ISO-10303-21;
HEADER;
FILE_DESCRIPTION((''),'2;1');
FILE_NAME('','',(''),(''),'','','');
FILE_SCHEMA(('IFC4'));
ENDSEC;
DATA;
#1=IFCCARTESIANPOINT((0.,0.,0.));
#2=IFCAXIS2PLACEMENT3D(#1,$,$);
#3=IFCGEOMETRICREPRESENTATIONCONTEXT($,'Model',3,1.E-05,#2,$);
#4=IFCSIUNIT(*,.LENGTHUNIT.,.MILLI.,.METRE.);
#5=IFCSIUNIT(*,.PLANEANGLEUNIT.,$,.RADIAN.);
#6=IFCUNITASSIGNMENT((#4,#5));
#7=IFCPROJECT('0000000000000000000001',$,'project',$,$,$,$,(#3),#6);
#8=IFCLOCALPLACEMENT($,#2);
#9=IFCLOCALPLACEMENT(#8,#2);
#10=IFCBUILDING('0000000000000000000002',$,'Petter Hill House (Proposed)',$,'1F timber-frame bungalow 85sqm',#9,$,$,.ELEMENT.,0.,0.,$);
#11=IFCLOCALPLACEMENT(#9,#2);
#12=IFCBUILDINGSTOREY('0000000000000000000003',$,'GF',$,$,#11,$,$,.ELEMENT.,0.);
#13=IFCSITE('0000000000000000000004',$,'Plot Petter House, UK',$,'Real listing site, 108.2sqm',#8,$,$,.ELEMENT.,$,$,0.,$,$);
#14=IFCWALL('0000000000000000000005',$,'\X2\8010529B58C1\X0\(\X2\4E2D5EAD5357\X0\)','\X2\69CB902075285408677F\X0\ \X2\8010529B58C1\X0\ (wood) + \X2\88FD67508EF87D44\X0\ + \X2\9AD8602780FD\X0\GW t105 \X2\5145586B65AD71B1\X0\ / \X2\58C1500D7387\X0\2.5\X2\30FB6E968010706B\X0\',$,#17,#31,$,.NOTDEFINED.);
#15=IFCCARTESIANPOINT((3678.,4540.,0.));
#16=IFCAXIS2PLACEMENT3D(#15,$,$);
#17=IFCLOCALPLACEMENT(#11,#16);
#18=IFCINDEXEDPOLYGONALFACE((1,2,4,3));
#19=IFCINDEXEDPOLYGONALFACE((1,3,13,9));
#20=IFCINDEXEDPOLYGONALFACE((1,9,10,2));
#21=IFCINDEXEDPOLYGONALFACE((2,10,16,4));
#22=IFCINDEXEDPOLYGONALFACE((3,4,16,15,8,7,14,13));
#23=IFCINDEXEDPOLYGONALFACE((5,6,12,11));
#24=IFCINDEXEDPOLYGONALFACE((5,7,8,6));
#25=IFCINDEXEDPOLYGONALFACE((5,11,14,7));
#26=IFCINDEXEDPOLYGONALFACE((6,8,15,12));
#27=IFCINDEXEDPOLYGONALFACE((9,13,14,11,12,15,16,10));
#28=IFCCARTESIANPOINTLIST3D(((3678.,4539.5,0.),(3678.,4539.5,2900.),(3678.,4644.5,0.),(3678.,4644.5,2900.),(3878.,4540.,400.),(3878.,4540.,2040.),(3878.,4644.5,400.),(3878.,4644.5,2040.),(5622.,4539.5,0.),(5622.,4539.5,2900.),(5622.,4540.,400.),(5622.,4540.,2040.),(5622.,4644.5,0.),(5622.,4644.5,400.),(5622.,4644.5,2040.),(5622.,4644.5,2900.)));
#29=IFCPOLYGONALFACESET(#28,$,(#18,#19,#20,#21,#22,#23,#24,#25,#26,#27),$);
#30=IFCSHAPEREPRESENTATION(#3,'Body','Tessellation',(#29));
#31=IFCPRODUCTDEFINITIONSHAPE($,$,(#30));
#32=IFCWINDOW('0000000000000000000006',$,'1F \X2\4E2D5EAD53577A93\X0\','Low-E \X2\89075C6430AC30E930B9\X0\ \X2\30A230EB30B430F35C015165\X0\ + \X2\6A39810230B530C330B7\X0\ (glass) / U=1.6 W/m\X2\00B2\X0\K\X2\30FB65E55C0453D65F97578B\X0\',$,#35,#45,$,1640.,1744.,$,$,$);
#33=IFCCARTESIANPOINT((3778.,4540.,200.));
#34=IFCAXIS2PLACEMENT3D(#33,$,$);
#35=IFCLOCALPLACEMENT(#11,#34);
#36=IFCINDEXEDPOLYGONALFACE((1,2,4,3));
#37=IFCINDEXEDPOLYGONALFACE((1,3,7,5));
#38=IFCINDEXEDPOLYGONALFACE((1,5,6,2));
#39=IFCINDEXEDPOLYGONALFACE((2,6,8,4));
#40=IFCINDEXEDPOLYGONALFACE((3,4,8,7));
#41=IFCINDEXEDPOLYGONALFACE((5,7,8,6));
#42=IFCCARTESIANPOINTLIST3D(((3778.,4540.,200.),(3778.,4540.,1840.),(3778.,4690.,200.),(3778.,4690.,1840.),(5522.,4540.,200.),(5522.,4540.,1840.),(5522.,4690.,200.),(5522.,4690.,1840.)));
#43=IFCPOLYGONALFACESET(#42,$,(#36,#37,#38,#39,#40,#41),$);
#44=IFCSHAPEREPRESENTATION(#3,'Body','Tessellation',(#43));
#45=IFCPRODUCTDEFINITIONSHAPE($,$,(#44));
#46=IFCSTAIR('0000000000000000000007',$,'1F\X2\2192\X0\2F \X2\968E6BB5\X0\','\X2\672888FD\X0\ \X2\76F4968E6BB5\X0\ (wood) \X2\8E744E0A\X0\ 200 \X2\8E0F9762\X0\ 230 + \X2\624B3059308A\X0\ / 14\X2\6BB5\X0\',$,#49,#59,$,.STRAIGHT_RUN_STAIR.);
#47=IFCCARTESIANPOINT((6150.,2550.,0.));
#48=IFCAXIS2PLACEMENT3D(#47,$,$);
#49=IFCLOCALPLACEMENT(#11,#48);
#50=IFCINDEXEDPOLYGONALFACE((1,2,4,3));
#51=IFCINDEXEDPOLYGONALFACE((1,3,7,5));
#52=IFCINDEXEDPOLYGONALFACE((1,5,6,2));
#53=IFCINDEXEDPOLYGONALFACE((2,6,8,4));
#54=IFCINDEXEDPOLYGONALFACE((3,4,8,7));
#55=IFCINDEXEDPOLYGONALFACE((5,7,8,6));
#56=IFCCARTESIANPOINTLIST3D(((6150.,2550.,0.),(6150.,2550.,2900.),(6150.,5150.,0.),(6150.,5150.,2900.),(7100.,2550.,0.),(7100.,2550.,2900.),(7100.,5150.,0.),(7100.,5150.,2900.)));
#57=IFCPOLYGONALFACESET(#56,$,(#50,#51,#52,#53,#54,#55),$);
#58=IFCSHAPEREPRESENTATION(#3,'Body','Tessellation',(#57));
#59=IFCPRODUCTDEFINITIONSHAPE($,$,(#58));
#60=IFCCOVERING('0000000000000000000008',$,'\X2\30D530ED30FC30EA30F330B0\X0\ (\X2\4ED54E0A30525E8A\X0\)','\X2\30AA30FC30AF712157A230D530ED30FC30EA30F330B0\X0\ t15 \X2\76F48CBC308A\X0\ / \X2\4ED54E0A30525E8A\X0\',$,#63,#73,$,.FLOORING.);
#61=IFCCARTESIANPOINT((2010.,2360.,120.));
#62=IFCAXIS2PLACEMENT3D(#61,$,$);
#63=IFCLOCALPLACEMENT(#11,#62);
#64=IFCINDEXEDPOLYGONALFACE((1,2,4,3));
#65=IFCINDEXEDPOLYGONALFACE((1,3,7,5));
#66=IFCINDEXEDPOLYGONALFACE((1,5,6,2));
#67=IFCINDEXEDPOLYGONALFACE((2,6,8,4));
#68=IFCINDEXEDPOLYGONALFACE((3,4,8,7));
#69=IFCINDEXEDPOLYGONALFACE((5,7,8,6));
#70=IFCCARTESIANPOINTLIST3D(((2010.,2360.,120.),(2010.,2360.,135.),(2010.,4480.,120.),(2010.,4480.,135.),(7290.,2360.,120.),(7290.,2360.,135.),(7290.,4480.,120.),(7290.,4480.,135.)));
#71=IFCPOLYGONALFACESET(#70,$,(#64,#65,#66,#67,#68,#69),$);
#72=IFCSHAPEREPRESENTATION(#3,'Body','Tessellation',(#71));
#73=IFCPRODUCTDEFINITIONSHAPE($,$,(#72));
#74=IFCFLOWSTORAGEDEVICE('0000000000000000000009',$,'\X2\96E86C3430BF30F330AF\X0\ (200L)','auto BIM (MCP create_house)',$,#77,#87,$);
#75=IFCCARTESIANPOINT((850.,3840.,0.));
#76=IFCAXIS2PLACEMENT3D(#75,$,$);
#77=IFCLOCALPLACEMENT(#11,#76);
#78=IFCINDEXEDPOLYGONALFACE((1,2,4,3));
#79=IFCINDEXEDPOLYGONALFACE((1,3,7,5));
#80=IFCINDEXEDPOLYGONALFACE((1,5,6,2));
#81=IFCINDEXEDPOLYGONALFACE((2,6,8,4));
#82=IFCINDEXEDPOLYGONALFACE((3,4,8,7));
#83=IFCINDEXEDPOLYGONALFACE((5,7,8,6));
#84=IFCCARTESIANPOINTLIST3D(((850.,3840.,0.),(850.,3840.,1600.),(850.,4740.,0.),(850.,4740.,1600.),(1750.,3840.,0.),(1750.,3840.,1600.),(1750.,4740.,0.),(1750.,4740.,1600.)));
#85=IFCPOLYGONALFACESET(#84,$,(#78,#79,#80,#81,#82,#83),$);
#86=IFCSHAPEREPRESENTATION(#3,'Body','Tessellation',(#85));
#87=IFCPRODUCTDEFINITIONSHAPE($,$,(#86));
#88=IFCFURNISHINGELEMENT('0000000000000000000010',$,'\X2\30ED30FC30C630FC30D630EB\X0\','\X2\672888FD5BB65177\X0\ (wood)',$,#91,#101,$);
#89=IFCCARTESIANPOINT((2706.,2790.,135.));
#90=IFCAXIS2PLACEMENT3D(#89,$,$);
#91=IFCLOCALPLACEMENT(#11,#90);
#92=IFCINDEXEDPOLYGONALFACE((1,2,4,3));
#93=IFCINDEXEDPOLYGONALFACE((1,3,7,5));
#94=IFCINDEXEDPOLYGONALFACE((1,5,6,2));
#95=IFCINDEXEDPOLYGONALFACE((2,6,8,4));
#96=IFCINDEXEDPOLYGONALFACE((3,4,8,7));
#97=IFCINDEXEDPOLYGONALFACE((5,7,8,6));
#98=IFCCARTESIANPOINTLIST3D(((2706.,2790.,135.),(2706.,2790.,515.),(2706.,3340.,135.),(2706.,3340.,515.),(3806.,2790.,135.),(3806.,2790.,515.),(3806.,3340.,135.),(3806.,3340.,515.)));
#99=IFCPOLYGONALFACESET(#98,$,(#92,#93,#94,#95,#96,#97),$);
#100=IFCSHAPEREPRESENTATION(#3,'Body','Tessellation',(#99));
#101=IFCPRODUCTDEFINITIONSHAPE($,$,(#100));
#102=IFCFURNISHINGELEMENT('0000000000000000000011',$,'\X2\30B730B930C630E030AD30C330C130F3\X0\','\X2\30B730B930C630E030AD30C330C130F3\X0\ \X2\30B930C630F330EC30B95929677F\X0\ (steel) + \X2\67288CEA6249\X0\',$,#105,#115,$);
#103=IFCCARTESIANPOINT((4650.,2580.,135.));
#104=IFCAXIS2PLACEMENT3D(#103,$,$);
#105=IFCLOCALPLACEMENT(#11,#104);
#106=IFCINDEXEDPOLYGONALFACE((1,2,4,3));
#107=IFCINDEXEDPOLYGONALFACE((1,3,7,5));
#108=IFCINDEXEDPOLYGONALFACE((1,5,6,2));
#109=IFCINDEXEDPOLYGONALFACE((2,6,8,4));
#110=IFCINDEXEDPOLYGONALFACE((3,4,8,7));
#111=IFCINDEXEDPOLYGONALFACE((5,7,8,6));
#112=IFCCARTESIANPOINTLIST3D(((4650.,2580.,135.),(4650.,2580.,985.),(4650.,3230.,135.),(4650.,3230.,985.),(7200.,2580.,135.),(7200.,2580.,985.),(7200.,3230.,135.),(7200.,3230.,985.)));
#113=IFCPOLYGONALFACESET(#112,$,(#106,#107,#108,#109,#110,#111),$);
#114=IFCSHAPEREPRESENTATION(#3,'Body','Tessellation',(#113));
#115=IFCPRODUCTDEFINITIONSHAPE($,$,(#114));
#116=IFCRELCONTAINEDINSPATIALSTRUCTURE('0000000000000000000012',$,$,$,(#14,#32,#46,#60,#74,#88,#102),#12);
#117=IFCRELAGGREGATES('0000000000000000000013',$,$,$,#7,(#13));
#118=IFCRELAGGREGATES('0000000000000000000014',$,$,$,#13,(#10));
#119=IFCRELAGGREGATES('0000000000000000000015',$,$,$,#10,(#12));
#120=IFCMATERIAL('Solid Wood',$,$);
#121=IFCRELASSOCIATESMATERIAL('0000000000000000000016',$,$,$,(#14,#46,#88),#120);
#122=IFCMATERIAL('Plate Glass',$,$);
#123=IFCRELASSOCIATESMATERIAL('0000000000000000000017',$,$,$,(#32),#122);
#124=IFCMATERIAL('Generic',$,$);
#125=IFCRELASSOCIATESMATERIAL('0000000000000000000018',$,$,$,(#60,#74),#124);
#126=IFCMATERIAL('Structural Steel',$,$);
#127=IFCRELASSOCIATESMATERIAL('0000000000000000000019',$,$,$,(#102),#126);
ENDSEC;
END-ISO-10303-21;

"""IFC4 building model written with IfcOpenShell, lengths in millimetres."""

from ifc_helpers import new_model, si_unit, frame, frame_2d, origin, place, context, project, spatial, rectangle, extrude, material, element, fill, save


model = new_model("IFC4")

# Units and contexts
model_context = context("Model", 3, precision=1e-05, world=origin())
ifc_project = project(units=[si_unit("LENGTHUNIT", "METRE", prefix="MILLI"), si_unit("PLANEANGLEUNIT", "RADIAN")], contexts=[model_context])

# Site, building, storey
site_placement = place(None, origin())
site = spatial("IfcSite", under=ifc_project, at=site_placement, Name="Plot Petter House, UK", ObjectType="Real listing site, 108.2sqm", CompositionType="ELEMENT", RefElevation=0.0)
building_placement = place(site_placement, origin())
building = spatial("IfcBuilding", under=site, at=building_placement, Name="Petter Hill House (Proposed)", ObjectType="1F timber-frame bungalow 85sqm", CompositionType="ELEMENT", ElevationOfRefHeight=0.0, ElevationOfTerrain=0.0)
storey_placement = place(building_placement, origin())
storey = spatial("IfcBuildingStorey", under=building, at=storey_placement, Name="GF", CompositionType="ELEMENT", Elevation=0.0)

# Shared definitions
ifc_material_1 = material(Name="Solid Wood")

# Shared definitions
ifc_material_2 = material(Name="Plate Glass")

# Wall, opening, window
wall_1_placement = place(storey_placement, frame((3678.0, 4540.0, 0.0)))
wall_1 = element("IfcWall", 1, at=wall_1_placement, inside=storey, material=ifc_material_1, Name="耐力壁(中庭南)", Description="構造用合板 耐力壁 (wood) + 製材軸組 + 高性能GW t105 充填断熱 / 壁倍率2.5・準耐火", PredefinedType="NOTDEFINED", context=model_context, shape_type="SweptSolid", body=[
    extrude(rectangle(XDim=1944.0, YDim=105.0, at=frame_2d((972.0, 52.0))), frame((3678.0, 4540.0, 0.0)), (0.0, 0.0, 1.0), 2900.0),
])
opening_1_placement = place(storey_placement, frame((3778.0, 4540.0, 200.0)))
opening_1 = element("IfcOpeningElement", 2, at=opening_1_placement, cuts=wall_1, PredefinedType="NOTDEFINED", context=model_context, shape_type="SweptSolid", body=[
    extrude(rectangle(XDim=1744.0, YDim=150.0, at=frame_2d((872.0, 75.0))), frame((3778.0, 4540.0, 200.0)), (0.0, 0.0, 1.0), 1640.0),
])
window_1_placement = place(storey_placement, frame((3778.0, 4540.0, 200.0)))
window_1 = element("IfcWindow", 3, at=window_1_placement, inside=storey, material=ifc_material_2, Name="1F 中庭南窓", Description="Low-E 複層ガラス アルゴン封入 + 樹脂サッシ (glass) / U=1.6 W/m²K・日射取得型", OverallHeight=1640.0, OverallWidth=1744.0, context=model_context, shape_type="SweptSolid", body=[
    extrude(rectangle(XDim=1744.0, YDim=150.0, at=frame_2d((872.0, 75.0))), frame((3778.0, 4540.0, 200.0)), (0.0, 0.0, 1.0), 1640.0),
])
fill(opening_1, window_1)

# Stair
stair_placement = place(storey_placement, frame((6150.0, 2550.0, 0.0)))
element("IfcStair", 4, at=stair_placement, inside=storey, material=ifc_material_1, Name="1F→2F 階段", Description="木製 直階段 (wood) 蹴上 200 踏面 230 + 手すり / 14段", PredefinedType="STRAIGHT_RUN_STAIR", context=model_context, shape_type="SweptSolid", body=[
    extrude(rectangle(XDim=950.0, YDim=2600.0, at=frame_2d((475.0, 1300.0))), frame((6150.0, 2550.0, 0.0)), (0.0, 0.0, 1.0), 2900.0),
])

# Covering
ifc_material_3 = material(Name="Generic")
covering_placement = place(storey_placement, frame((2010.0, 2360.0, 120.0)))
element("IfcCovering", 5, at=covering_placement, inside=storey, material=ifc_material_3, Name="フローリング (仕上げ床)", Description="オーク無垢フローリング t15 直貼り / 仕上げ床", PredefinedType="FLOORING", context=model_context, shape_type="SweptSolid", body=[
    extrude(rectangle(XDim=5280.0, YDim=2120.0, at=frame_2d((2640.0, 1060.0))), frame((2010.0, 2360.0, 120.0)), (0.0, 0.0, 1.0), 15.0),
])

# Flow storage device
flow_storage_device_placement = place(storey_placement, frame((850.0, 3840.0, 0.0)))
element("IfcFlowStorageDevice", 6, at=flow_storage_device_placement, inside=storey, material=ifc_material_3, Name="雨水タンク (200L)", Description="auto BIM (MCP create_house)", context=model_context, shape_type="SweptSolid", body=[
    extrude(rectangle(XDim=900.0, YDim=900.0, at=frame_2d((450.0, 450.0))), frame((850.0, 3840.0, 0.0)), (0.0, 0.0, 1.0), 1600.0),
])

# Furnishing elements
furnishing_1_placement = place(storey_placement, frame((2706.0, 2790.0, 135.0)))
element("IfcFurnishingElement", 7, at=furnishing_1_placement, inside=storey, material=ifc_material_1, Name="ローテーブル", Description="木製家具 (wood)", context=model_context, shape_type="SweptSolid", body=[
    extrude(rectangle(XDim=1100.0, YDim=550.0, at=frame_2d((550.0, 275.0))), frame((2706.0, 2790.0, 135.0)), (0.0, 0.0, 1.0), 380.0),
])
ifc_material_4 = material(Name="Structural Steel")
furnishing_2_placement = place(storey_placement, frame((4650.0, 2580.0, 135.0)))
element("IfcFurnishingElement", 8, at=furnishing_2_placement, inside=storey, material=ifc_material_4, Name="システムキッチン", Description="システムキッチン ステンレス天板 (steel) + 木質扉", context=model_context, shape_type="SweptSolid", body=[
    extrude(rectangle(XDim=2550.0, YDim=650.0, at=frame_2d((1275.0, 325.0))), frame((4650.0, 2580.0, 135.0)), (0.0, 0.0, 1.0), 850.0),
])

save(model, "model.ifc")
